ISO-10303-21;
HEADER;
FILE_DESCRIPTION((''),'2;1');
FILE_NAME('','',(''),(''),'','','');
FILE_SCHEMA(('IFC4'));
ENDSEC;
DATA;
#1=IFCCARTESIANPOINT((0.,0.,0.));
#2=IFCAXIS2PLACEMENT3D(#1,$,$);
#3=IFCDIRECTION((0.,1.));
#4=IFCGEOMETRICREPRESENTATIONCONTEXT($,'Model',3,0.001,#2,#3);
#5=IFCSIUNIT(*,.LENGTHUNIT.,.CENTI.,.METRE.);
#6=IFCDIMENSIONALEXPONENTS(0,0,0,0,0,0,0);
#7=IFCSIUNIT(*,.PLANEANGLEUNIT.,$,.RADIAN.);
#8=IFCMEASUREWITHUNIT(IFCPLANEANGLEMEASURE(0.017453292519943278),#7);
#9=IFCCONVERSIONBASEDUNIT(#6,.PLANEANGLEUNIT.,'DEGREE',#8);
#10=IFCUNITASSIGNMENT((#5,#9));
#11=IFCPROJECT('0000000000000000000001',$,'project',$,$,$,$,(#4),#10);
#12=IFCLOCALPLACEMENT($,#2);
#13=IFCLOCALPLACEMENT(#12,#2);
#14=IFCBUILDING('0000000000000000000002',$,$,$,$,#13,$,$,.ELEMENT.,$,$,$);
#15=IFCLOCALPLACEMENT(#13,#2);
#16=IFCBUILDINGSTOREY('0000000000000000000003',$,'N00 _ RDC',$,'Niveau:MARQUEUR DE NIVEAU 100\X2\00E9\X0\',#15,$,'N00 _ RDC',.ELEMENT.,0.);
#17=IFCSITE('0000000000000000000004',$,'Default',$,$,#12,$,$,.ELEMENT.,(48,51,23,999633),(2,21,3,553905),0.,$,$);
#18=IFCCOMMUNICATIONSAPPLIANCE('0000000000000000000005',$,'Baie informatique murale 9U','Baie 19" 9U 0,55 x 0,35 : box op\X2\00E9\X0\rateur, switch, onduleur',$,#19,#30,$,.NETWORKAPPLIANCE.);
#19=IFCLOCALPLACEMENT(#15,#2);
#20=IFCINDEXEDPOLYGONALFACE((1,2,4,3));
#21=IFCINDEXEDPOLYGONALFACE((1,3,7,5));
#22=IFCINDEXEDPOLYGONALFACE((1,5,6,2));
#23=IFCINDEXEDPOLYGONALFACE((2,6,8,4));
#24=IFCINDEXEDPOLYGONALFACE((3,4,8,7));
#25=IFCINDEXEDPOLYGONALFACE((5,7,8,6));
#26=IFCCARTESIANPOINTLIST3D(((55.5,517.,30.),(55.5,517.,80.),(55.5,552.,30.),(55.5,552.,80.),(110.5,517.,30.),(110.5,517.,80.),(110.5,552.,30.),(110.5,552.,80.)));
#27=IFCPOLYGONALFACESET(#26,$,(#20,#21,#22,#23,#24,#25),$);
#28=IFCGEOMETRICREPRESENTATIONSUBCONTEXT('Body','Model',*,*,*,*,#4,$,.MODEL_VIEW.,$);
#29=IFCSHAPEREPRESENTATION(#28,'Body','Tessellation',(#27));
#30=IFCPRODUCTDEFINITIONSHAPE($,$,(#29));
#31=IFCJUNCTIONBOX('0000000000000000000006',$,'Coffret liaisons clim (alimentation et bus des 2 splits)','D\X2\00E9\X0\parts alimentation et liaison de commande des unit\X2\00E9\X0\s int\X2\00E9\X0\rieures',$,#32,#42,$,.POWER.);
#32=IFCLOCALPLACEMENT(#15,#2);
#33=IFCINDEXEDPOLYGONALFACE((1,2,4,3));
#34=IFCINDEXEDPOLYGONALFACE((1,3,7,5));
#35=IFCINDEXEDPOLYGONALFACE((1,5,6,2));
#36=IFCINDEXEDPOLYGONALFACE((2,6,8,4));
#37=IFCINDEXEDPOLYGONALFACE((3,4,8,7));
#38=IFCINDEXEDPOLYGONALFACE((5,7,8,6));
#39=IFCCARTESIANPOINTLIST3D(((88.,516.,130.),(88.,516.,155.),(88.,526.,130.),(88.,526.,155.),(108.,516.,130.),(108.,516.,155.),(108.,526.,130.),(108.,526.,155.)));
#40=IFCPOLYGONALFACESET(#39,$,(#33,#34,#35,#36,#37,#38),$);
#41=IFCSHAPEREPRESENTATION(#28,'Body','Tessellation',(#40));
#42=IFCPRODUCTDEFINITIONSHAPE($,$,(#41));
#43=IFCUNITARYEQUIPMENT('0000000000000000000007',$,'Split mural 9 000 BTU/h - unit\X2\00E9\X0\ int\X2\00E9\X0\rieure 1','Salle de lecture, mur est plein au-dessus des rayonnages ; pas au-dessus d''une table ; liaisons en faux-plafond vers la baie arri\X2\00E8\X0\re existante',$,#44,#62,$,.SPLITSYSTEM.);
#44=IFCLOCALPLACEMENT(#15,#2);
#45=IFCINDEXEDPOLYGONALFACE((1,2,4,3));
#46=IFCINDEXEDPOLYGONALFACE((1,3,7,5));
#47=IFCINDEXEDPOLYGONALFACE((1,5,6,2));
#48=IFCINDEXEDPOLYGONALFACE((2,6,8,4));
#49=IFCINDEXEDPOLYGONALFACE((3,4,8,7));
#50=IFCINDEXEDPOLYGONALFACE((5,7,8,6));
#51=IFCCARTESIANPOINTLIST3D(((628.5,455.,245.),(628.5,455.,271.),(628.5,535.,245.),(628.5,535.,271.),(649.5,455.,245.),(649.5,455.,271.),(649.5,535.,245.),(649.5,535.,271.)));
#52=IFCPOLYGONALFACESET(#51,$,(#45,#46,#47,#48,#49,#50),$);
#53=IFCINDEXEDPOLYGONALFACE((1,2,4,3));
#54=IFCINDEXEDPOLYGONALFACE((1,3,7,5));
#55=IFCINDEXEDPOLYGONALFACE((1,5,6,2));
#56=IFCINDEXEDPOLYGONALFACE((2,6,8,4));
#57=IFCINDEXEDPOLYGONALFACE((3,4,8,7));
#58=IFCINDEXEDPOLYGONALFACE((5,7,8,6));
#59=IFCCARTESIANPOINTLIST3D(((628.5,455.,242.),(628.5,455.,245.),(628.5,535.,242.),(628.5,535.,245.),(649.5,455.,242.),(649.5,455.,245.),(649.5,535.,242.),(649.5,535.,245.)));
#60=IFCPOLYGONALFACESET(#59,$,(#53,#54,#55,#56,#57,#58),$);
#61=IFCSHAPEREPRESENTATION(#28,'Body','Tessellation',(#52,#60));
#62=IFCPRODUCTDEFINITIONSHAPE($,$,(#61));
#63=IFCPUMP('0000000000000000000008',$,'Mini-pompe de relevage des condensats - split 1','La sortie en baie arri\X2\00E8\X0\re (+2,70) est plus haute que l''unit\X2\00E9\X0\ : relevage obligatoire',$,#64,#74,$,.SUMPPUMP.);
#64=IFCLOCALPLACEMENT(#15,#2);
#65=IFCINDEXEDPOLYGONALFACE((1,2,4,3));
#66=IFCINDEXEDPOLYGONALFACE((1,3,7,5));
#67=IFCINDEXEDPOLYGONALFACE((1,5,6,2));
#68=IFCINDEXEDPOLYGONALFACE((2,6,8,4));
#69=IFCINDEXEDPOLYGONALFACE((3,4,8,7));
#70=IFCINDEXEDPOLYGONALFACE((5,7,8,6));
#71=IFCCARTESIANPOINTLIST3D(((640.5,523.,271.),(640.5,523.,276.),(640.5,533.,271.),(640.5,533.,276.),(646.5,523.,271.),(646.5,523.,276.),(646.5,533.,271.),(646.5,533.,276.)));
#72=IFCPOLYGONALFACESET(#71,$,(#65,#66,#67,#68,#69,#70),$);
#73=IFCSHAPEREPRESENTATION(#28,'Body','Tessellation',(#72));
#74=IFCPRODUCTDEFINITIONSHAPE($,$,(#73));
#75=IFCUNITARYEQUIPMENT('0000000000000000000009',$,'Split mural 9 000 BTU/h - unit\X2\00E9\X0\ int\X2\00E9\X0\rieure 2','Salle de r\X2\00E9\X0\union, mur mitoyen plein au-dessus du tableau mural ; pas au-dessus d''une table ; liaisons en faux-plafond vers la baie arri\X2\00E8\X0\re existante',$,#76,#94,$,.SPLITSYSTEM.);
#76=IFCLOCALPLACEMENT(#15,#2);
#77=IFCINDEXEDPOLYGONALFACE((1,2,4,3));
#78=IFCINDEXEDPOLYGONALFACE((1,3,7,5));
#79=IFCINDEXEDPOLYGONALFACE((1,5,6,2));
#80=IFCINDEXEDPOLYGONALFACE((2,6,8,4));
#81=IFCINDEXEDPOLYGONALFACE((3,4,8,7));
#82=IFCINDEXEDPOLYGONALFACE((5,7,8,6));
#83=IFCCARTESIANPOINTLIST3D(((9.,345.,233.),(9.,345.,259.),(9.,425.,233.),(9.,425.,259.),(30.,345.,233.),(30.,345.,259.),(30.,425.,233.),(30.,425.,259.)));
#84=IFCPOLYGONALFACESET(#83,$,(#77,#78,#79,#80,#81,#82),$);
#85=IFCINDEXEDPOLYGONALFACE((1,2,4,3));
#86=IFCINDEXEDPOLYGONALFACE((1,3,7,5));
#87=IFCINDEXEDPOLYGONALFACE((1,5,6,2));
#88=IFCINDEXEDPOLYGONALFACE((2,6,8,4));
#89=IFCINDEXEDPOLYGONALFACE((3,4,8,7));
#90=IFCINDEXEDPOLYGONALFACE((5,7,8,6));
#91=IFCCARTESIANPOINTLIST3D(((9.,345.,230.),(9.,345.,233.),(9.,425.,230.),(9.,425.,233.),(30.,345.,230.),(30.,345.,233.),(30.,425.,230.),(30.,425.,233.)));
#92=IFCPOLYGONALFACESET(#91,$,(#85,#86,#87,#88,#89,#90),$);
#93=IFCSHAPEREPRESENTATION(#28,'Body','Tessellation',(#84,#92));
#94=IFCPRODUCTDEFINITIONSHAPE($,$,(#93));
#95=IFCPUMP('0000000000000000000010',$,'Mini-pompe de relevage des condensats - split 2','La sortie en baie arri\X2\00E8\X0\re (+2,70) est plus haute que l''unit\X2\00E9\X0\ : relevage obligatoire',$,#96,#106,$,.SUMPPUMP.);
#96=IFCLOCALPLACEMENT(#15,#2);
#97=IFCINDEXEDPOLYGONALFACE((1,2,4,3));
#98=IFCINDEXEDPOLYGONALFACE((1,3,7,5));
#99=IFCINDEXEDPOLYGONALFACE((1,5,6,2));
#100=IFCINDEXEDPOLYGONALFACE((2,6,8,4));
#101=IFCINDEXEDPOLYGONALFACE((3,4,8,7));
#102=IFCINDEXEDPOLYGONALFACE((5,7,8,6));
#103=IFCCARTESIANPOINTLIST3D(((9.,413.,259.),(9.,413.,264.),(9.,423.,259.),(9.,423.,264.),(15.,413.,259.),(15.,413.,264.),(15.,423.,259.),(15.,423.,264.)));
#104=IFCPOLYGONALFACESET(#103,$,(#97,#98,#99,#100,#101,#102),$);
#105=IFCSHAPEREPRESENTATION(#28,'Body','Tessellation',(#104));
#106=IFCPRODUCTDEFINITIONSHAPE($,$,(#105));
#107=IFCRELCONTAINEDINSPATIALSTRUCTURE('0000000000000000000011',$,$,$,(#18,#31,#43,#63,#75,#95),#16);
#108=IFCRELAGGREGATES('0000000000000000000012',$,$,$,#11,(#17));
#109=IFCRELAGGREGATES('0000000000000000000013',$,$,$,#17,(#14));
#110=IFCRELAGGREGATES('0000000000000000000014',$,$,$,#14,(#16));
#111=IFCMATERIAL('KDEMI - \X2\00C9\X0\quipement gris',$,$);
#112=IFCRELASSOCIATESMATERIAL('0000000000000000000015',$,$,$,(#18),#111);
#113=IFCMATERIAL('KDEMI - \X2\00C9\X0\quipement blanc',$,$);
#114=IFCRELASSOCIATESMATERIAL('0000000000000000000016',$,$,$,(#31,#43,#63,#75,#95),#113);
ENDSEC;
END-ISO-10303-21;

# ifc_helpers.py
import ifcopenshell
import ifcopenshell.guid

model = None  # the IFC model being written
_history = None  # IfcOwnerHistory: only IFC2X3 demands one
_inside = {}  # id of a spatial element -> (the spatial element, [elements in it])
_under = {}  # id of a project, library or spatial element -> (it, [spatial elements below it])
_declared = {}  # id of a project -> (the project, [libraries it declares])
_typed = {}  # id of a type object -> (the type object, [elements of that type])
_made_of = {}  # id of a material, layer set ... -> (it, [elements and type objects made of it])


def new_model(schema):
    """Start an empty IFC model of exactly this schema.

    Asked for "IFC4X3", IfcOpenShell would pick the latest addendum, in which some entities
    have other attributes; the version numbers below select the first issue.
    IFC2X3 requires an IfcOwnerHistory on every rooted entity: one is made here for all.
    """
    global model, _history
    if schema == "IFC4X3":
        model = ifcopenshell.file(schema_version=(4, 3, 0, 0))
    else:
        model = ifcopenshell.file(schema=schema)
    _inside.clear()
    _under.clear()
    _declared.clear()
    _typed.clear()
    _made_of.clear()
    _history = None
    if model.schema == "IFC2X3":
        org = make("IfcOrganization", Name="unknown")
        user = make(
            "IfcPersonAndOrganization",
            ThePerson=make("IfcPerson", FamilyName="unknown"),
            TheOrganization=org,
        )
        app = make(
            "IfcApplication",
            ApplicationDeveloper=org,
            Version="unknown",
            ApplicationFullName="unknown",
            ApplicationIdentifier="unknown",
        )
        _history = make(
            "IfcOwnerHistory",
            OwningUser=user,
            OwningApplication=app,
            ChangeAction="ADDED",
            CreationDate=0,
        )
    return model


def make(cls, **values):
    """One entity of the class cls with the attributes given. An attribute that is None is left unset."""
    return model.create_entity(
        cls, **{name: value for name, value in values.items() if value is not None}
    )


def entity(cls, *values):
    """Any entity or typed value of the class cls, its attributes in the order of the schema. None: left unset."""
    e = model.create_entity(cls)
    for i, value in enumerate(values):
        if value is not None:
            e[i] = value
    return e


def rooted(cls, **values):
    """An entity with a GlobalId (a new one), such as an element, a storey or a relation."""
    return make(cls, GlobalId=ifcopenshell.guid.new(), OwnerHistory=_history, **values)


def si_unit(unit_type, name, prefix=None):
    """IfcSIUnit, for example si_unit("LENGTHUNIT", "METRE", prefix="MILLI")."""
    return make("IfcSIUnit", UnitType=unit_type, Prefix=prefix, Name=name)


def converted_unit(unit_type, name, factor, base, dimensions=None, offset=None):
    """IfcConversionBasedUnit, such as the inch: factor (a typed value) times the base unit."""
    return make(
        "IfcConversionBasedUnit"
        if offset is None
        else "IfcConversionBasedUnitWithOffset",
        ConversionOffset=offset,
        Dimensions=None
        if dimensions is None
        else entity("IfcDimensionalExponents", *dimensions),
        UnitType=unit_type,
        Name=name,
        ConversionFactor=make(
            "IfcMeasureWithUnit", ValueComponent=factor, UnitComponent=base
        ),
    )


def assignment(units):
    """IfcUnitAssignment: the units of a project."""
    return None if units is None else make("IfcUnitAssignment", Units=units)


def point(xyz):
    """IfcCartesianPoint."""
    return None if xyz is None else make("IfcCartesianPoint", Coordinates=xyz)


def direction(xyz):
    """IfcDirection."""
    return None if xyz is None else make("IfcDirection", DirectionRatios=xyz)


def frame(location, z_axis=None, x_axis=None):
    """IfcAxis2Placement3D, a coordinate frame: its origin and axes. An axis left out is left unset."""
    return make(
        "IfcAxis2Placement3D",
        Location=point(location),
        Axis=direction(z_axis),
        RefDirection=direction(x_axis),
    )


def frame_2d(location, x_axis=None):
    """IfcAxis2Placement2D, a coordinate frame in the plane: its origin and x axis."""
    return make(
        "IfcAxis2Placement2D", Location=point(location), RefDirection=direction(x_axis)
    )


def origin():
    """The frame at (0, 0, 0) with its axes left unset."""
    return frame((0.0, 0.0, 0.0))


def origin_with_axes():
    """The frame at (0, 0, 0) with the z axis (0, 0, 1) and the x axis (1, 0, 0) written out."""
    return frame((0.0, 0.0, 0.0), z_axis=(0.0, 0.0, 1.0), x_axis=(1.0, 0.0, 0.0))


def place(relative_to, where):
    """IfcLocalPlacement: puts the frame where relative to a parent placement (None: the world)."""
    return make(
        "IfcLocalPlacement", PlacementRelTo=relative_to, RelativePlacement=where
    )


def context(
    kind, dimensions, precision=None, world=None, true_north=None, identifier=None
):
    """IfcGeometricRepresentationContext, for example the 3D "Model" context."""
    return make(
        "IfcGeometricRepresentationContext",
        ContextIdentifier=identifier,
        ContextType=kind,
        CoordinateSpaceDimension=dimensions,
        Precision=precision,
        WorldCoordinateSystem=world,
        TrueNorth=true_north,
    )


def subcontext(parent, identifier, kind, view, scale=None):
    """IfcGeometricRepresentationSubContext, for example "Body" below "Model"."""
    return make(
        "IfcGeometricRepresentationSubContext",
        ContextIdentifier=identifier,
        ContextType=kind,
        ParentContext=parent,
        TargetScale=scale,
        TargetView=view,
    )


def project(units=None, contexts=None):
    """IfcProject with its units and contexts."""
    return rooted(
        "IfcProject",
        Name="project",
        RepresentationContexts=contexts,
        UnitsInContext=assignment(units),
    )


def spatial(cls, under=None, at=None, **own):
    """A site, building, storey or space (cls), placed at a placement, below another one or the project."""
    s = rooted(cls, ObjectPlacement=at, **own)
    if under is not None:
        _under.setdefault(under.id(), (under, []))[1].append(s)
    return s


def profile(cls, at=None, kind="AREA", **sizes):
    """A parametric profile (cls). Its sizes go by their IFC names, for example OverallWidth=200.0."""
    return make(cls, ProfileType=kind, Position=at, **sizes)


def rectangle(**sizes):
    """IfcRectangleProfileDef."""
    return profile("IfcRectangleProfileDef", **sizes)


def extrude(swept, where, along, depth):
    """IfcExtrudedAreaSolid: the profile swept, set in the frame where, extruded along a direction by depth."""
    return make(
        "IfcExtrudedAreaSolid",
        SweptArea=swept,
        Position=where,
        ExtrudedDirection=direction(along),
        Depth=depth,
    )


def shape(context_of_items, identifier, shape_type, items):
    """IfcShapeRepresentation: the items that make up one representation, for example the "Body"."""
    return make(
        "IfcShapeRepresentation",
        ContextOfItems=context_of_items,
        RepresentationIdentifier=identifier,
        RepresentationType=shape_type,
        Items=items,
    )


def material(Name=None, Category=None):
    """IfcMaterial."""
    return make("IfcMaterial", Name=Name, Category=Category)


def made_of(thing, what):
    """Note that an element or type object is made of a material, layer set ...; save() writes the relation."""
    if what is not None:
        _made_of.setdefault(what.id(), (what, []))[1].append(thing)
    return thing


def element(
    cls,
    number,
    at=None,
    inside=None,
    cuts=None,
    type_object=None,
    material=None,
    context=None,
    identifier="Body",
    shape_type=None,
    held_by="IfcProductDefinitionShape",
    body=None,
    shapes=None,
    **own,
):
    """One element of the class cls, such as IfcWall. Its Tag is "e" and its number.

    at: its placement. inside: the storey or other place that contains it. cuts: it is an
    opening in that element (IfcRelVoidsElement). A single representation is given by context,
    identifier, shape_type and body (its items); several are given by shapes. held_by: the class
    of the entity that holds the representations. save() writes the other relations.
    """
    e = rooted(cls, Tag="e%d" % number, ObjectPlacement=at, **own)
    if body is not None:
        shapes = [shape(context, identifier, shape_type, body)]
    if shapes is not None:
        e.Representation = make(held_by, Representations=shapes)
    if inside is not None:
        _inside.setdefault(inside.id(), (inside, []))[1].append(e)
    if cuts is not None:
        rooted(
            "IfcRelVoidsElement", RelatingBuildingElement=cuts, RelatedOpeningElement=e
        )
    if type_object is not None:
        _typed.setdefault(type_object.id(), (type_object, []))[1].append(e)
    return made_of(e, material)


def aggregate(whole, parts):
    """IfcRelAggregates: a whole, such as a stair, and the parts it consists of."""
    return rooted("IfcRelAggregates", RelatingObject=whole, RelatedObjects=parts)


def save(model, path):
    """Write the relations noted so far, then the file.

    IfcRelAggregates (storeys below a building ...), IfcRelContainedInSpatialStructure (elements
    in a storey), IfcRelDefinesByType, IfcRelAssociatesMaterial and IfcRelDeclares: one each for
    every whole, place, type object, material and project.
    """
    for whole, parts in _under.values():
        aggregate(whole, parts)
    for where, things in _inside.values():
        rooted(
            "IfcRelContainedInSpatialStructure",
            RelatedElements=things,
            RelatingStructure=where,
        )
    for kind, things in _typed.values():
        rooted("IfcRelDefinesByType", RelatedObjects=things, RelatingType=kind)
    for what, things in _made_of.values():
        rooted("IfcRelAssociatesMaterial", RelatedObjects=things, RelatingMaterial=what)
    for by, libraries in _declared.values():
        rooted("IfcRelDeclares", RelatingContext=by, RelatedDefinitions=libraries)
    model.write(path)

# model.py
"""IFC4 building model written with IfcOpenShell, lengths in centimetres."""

from ifc_helpers import new_model, entity, si_unit, converted_unit, direction, frame, frame_2d, origin, origin_with_axes, place, context, subcontext, project, spatial, rectangle, extrude, material, element, save


model = new_model("IFC4")

# Units and contexts
model_context = context("Model", 3, precision=0.001, world=origin(), true_north=direction((0.0, 1.0)))
body_context = subcontext(model_context, "Body", "Model", "MODEL_VIEW")
ifc_project = project(units=[si_unit("LENGTHUNIT", "METRE", prefix="CENTI"), converted_unit("PLANEANGLEUNIT", "DEGREE", entity("IfcPlaneAngleMeasure", 0.017453292519943278), si_unit("PLANEANGLEUNIT", "RADIAN"), dimensions=[0, 0, 0, 0, 0, 0, 0])], contexts=[model_context])

# Site, building, storey
site_placement = place(None, origin())
site = spatial("IfcSite", under=ifc_project, at=site_placement, Name="Default", CompositionType="ELEMENT", RefLatitude=(48, 51, 23, 999633), RefLongitude=(2, 21, 3, 553905), RefElevation=0.0)
building_placement = place(site_placement, origin())
building = spatial("IfcBuilding", under=site, at=building_placement, CompositionType="ELEMENT")
storey_placement = place(building_placement, origin())
storey = spatial("IfcBuildingStorey", under=building, at=storey_placement, Name="N00 _ RDC", ObjectType="Niveau:MARQUEUR DE NIVEAU 100é", LongName="N00 _ RDC", CompositionType="ELEMENT", Elevation=0.0)

# Shared definitions
ifc_material_1 = material(Name="KDEMI - Équipement blanc")

# Communications appliance
ifc_material_2 = material(Name="KDEMI - Équipement gris")
communications_appliance_placement = place(storey_placement, origin_with_axes())
element("IfcCommunicationsAppliance", 1, at=communications_appliance_placement, inside=storey, material=ifc_material_2, Name="Baie informatique murale 9U", Description="Baie 19\" 9U 0,55 x 0,35 : box opérateur, switch, onduleur", PredefinedType="NETWORKAPPLIANCE", context=body_context, shape_type="SweptSolid", body=[
    extrude(rectangle(XDim=55.0, YDim=35.0, at=frame_2d((83.0, 534.5))), frame((0.0, 0.0, 30.0)), (0.0, 0.0, 1.0), 50.0),
])

# Junction box
junction_box_placement = place(storey_placement, origin_with_axes())
element("IfcJunctionBox", 2, at=junction_box_placement, inside=storey, material=ifc_material_1, Name="Coffret liaisons clim (alimentation et bus des 2 splits)", Description="Départs alimentation et liaison de commande des unités intérieures", PredefinedType="POWER", context=body_context, shape_type="SweptSolid", body=[
    extrude(rectangle(XDim=20.0, YDim=10.0, at=frame_2d((98.0, 521.0))), frame((0.0, 0.0, 130.0)), (0.0, 0.0, 1.0), 25.0),
])

# Unitary equipment
unitary_equipment_1_placement = place(storey_placement, origin_with_axes())
element("IfcUnitaryEquipment", 3, at=unitary_equipment_1_placement, inside=storey, material=ifc_material_1, Name="Split mural 9 000 BTU/h - unité intérieure 1", Description="Salle de lecture, mur est plein au-dessus des rayonnages ; pas au-dessus d'une table ; liaisons en faux-plafond vers la baie arrière existante", PredefinedType="SPLITSYSTEM", context=body_context, shape_type="SweptSolid", body=[
    extrude(rectangle(XDim=21.0, YDim=80.0, at=frame_2d((639.0, 495.0))), frame((0.0, 0.0, 245.0)), (0.0, 0.0, 1.0), 26.0),
    extrude(rectangle(XDim=21.0, YDim=80.0, at=frame_2d((639.0, 495.0))), frame((0.0, 0.0, 242.0)), (0.0, 0.0, 1.0), 3.0),
])

# Pump
pump_1_placement = place(storey_placement, origin_with_axes())
element("IfcPump", 4, at=pump_1_placement, inside=storey, material=ifc_material_1, Name="Mini-pompe de relevage des condensats - split 1", Description="La sortie en baie arrière (+2,70) est plus haute que l'unité : relevage obligatoire", PredefinedType="SUMPPUMP", context=body_context, shape_type="SweptSolid", body=[
    extrude(rectangle(XDim=6.0, YDim=10.0, at=frame_2d((643.5, 528.0))), frame((0.0, 0.0, 271.0)), (0.0, 0.0, 1.0), 5.0),
])

# Unitary equipment
unitary_equipment_2_placement = place(storey_placement, origin_with_axes())
element("IfcUnitaryEquipment", 5, at=unitary_equipment_2_placement, inside=storey, material=ifc_material_1, Name="Split mural 9 000 BTU/h - unité intérieure 2", Description="Salle de réunion, mur mitoyen plein au-dessus du tableau mural ; pas au-dessus d'une table ; liaisons en faux-plafond vers la baie arrière existante", PredefinedType="SPLITSYSTEM", context=body_context, shape_type="SweptSolid", body=[
    extrude(rectangle(XDim=21.0, YDim=80.0, at=frame_2d((19.5, 385.0))), frame((0.0, 0.0, 233.0)), (0.0, 0.0, 1.0), 26.0),
    extrude(rectangle(XDim=21.0, YDim=80.0, at=frame_2d((19.5, 385.0))), frame((0.0, 0.0, 230.0)), (0.0, 0.0, 1.0), 3.0),
])

# Pump
pump_2_placement = place(storey_placement, origin_with_axes())
element("IfcPump", 6, at=pump_2_placement, inside=storey, material=ifc_material_1, Name="Mini-pompe de relevage des condensats - split 2", Description="La sortie en baie arrière (+2,70) est plus haute que l'unité : relevage obligatoire", PredefinedType="SUMPPUMP", context=body_context, shape_type="SweptSolid", body=[
    extrude(rectangle(XDim=6.0, YDim=10.0, at=frame_2d((12.0, 418.0))), frame((0.0, 0.0, 259.0)), (0.0, 0.0, 1.0), 5.0),
])

save(model, "model.ifc")
